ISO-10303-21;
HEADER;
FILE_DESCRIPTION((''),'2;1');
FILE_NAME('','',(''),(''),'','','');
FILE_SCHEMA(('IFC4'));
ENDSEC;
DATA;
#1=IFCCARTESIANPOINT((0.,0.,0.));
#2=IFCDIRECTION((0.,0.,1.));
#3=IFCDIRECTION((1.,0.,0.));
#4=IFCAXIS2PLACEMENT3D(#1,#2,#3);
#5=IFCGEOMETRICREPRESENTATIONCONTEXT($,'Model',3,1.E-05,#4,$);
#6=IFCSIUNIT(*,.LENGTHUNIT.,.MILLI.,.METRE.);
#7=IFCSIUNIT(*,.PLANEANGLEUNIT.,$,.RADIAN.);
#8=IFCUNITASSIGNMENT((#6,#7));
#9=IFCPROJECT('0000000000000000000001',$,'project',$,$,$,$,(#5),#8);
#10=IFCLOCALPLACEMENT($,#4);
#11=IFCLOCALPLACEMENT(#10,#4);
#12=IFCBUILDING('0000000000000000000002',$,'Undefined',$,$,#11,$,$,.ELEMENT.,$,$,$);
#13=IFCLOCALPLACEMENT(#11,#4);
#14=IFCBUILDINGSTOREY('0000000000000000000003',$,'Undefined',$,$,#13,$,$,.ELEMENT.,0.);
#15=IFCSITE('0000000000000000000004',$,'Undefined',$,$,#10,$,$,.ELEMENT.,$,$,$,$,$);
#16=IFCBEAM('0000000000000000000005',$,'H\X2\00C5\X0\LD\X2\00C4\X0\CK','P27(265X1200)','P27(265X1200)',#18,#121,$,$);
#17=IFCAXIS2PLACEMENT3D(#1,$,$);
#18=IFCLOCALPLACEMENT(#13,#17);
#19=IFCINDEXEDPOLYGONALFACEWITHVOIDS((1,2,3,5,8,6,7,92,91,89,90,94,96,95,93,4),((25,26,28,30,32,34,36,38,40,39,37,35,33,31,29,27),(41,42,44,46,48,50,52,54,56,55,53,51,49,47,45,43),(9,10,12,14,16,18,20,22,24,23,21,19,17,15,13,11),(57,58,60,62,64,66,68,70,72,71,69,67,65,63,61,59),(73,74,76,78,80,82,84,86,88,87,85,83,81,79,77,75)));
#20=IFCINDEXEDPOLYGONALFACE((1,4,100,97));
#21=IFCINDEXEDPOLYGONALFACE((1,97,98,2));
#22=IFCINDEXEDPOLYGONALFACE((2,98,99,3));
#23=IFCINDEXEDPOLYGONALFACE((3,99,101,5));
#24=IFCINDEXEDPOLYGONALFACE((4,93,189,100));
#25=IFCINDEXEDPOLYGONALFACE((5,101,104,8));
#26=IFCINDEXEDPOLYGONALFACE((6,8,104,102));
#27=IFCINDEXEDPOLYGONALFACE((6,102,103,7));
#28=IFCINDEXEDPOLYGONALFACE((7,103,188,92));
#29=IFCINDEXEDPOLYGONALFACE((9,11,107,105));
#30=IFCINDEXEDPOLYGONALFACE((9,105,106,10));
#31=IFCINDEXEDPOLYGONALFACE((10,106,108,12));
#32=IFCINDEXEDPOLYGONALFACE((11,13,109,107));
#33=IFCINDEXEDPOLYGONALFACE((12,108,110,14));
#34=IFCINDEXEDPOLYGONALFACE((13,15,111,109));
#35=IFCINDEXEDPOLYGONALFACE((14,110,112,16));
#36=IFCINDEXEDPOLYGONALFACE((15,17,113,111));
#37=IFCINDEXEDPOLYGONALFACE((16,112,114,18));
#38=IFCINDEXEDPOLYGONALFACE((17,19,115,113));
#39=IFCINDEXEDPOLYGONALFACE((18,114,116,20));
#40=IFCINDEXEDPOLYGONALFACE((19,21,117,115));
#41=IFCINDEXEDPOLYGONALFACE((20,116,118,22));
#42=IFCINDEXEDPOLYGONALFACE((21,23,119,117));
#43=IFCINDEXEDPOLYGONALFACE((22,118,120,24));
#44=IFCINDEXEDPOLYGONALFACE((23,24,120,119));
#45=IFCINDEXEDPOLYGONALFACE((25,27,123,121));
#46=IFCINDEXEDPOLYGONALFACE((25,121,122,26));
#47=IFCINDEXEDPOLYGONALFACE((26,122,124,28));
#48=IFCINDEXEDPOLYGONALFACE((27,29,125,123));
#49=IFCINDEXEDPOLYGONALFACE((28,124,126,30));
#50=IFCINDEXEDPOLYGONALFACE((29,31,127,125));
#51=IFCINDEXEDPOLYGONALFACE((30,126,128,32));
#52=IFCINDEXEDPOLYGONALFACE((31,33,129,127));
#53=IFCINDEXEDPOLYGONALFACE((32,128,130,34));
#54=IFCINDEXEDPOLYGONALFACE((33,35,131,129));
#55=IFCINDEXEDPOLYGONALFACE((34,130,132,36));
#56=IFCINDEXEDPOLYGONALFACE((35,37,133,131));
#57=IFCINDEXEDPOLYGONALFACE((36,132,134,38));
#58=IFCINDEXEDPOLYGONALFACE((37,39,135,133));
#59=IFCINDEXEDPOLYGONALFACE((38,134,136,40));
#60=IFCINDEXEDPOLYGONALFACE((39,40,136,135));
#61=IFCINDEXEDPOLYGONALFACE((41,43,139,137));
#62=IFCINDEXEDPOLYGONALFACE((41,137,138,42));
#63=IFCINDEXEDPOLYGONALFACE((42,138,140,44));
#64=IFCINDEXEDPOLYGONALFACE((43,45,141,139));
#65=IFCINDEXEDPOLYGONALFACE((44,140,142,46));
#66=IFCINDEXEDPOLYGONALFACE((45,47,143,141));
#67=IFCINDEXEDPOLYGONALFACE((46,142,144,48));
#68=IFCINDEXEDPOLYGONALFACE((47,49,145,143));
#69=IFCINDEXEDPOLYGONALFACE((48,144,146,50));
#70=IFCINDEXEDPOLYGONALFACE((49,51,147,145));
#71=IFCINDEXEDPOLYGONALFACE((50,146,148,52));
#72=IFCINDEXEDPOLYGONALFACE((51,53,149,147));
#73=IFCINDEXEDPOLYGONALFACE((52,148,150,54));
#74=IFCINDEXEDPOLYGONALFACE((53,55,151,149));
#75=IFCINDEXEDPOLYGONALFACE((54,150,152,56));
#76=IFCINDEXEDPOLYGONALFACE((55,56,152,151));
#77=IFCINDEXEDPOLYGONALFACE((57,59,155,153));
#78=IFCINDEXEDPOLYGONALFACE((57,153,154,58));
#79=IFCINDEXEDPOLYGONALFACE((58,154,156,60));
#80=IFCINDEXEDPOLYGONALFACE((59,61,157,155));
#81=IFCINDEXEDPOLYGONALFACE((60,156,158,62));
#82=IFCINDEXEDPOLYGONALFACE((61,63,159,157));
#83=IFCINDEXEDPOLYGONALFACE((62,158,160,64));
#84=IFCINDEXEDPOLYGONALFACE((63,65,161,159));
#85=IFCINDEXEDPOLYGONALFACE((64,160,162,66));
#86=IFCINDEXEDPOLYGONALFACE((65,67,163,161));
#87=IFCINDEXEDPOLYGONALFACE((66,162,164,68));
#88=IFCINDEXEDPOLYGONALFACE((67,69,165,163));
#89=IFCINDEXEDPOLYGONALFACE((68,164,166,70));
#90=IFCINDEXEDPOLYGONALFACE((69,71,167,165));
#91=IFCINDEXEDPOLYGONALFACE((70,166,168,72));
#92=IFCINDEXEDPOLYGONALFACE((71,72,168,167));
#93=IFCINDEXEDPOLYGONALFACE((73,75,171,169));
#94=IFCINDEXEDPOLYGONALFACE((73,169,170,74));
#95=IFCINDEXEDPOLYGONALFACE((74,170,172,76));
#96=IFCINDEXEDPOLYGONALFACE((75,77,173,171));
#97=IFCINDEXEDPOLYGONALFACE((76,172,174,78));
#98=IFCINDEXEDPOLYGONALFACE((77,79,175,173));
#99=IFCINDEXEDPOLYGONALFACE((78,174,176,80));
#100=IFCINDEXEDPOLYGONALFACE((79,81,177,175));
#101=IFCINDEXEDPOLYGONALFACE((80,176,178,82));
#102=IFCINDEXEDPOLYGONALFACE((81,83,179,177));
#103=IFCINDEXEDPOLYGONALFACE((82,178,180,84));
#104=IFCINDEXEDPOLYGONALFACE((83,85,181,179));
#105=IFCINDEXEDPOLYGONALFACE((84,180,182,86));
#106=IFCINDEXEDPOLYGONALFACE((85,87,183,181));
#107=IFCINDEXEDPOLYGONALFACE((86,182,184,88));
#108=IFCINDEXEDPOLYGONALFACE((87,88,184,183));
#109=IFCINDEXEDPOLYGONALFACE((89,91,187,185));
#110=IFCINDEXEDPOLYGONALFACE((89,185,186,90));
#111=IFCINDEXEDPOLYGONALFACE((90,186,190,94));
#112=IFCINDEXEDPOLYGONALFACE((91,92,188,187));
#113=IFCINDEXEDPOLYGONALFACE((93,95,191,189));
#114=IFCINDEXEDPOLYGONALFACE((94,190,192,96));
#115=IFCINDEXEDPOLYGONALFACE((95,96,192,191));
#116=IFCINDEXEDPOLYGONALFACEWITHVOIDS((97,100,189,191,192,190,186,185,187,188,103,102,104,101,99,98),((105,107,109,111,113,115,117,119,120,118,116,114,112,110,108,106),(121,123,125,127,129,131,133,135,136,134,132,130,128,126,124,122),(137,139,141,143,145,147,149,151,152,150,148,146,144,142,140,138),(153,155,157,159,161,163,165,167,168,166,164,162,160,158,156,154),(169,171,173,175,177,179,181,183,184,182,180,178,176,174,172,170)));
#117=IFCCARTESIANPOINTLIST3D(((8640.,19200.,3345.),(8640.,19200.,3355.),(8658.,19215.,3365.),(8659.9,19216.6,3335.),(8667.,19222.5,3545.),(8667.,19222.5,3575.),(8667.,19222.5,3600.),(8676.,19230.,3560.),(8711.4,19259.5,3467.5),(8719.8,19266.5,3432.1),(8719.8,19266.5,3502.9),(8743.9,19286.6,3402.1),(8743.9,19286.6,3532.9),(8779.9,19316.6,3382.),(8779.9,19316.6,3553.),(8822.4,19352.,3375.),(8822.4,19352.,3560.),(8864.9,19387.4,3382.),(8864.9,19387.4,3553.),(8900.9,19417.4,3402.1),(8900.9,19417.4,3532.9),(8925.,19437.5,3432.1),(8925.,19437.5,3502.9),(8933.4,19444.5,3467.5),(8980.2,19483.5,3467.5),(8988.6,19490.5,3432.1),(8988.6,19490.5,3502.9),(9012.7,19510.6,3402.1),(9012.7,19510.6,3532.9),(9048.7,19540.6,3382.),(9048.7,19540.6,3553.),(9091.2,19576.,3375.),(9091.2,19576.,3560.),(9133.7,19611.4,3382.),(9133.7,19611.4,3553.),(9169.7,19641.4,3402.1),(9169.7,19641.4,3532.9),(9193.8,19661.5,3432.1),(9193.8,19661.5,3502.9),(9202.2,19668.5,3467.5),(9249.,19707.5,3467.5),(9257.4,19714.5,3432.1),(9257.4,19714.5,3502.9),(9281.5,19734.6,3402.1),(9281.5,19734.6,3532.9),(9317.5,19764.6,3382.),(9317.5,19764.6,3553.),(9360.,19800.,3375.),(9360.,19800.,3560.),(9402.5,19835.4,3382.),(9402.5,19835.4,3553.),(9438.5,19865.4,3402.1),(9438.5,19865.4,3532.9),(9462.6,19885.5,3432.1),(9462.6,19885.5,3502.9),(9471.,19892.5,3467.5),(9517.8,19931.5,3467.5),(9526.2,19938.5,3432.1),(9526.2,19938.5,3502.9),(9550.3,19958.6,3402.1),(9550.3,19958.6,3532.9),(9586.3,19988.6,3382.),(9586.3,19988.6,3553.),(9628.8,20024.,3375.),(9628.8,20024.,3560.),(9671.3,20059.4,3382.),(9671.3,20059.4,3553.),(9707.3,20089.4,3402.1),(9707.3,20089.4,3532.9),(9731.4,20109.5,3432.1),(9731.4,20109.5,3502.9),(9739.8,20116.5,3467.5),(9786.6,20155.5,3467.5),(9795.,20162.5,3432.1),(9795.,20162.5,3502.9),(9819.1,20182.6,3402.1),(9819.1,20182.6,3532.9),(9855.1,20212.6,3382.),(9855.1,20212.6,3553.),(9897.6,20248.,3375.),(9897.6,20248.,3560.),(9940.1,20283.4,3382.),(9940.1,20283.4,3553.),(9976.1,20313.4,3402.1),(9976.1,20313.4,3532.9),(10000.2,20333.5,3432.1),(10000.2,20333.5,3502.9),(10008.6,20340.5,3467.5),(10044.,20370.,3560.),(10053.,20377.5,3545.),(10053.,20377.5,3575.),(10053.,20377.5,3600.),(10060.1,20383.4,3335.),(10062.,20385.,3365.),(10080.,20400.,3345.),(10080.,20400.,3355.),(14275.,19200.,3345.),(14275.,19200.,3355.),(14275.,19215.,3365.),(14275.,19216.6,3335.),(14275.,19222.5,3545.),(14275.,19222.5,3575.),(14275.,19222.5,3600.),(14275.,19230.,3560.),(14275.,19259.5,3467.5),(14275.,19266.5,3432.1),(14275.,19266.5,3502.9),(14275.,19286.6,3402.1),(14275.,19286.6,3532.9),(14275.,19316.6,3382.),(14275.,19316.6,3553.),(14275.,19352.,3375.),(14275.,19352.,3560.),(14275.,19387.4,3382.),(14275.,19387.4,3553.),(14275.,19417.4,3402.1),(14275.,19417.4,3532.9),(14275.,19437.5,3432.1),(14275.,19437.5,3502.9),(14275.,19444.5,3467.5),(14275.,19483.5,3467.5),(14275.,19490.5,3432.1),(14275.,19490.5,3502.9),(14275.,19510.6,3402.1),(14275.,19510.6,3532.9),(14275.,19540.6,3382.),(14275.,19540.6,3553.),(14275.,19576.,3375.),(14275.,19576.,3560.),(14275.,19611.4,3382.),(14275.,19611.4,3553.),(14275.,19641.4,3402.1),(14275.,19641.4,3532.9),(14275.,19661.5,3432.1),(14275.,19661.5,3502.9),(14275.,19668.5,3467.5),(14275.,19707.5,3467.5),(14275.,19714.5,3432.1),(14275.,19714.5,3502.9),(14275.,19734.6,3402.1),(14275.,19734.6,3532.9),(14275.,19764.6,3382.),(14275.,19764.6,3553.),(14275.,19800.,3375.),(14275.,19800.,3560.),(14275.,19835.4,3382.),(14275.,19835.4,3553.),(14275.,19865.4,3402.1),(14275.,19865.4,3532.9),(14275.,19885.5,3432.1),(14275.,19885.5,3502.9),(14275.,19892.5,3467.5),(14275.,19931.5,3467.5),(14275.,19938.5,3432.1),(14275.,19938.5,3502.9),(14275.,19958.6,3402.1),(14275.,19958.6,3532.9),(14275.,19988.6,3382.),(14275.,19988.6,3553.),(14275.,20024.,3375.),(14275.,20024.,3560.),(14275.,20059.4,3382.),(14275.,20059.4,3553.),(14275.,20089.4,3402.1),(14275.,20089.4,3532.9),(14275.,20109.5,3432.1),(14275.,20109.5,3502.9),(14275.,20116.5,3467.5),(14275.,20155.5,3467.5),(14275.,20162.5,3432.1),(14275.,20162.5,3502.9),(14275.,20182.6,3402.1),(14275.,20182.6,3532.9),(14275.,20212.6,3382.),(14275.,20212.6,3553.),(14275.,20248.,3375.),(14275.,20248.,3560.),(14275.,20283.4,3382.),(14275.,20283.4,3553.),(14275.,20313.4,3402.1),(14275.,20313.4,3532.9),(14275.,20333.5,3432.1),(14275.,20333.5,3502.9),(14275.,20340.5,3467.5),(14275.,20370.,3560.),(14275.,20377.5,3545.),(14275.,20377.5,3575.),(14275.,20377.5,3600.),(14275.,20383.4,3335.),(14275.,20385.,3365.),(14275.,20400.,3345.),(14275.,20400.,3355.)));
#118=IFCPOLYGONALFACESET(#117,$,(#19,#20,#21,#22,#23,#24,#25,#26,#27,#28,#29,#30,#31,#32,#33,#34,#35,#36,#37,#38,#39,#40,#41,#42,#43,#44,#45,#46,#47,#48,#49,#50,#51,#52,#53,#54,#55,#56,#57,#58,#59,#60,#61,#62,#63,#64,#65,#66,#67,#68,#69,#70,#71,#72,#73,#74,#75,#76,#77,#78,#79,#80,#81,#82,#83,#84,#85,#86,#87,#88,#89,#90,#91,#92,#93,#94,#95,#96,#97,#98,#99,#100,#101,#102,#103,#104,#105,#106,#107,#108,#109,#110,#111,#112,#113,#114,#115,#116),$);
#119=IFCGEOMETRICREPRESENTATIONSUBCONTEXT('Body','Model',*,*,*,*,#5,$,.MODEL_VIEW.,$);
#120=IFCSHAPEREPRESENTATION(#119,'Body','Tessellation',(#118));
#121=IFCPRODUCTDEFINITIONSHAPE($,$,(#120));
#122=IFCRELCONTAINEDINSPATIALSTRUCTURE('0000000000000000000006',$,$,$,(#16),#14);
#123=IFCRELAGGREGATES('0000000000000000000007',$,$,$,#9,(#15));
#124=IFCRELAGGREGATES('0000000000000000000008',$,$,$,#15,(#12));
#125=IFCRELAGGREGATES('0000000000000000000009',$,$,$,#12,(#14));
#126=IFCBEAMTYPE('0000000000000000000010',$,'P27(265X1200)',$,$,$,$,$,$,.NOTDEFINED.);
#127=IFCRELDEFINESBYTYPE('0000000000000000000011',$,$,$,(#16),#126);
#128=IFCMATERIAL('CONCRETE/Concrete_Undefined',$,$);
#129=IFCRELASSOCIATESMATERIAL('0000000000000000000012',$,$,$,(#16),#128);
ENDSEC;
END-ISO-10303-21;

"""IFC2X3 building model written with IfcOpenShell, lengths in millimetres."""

from ifc_helpers import new_model, si_unit, frame, origin_with_axes, place, context, subcontext, project, spatial, polyline, outline, extrude, clip, halfspace, material, type_object, element, save


model = new_model("IFC2X3")

# Units and contexts
model_context = context("Model", 3, precision=1e-05, world=origin_with_axes())
body_context = subcontext(model_context, "Body", "Model", "MODEL_VIEW")
ifc_project = project(units=[si_unit("LENGTHUNIT", "METRE", prefix="MILLI"), si_unit("PLANEANGLEUNIT", "RADIAN")], contexts=[model_context])

# Site, building, storey
site_placement = place(None, origin_with_axes())
site = spatial("IfcSite", under=ifc_project, at=site_placement, Name="Undefined", CompositionType="ELEMENT")
building_placement = place(site_placement, origin_with_axes())
building = spatial("IfcBuilding", under=site, at=building_placement, Name="Undefined", CompositionType="ELEMENT")
storey_placement = place(building_placement, origin_with_axes())
storey = spatial("IfcBuildingStorey", under=building, at=storey_placement, Name="Undefined", CompositionType="ELEMENT", Elevation=0.0)

# Beam
ifc_material_1 = material(Name="CONCRETE/Concrete_Undefined")
beam_type_1 = type_object("IfcBeamType", Name="P27(265X1200)", PredefinedType="NOTDEFINED")
beam_1_placement = place(storey_placement, frame((8640.0, 19800.0, 3467.5), z_axis=(0.0, 0.0, 1.0), x_axis=(1.0, 0.0, 0.0)))
element("IfcBeam", 1, at=beam_1_placement, inside=storey, type_object=beam_type_1, material=ifc_material_1, Name="HÅLDÄCK", Description="P27(265X1200)", ObjectType="P27(265X1200)", context=body_context, shape_type="Clipping", body=[
    clip(extrude(outline(polyline([(-583.4, -132.5), (-600.0, -122.5), (-600.0, -112.5), (-585.0, -102.5), (-577.5, 77.5), (-570.0, 92.5), (-577.5, 107.5), (-577.5, 132.5), (577.5, 132.5), (577.5, 107.5), (570.0, 92.5), (577.5, 77.5), (585.0, -102.5), (600.0, -112.5), (600.0, -122.5), (583.4, -132.5), (-583.4, -132.5)]), holes=[polyline([(-513.4, 65.4), (-533.5, 35.4), (-540.5, 0.0), (-533.5, -35.4), (-513.4, -65.4), (-483.4, -85.5), (-448.0, -92.5), (-412.6, -85.5), (-382.6, -65.4), (-362.5, -35.4), (-355.5, 0.0), (-362.5, 35.4), (-382.6, 65.4), (-412.6, 85.5), (-448.0, 92.5), (-483.4, 85.5), (-513.4, 65.4)]), polyline([(-289.4, 65.4), (-309.5, 35.4), (-316.5, 0.0), (-309.5, -35.4), (-289.4, -65.4), (-259.4, -85.5), (-224.0, -92.5), (-188.6, -85.5), (-158.6, -65.4), (-138.5, -35.4), (-131.5, 0.0), (-138.5, 35.4), (-158.6, 65.4), (-188.6, 85.5), (-224.0, 92.5), (-259.4, 85.5), (-289.4, 65.4)]), polyline([(-65.4, 65.4), (-85.5, 35.4), (-92.5, 0.0), (-85.5, -35.4), (-65.4, -65.4), (-35.4, -85.5), (0.0, -92.5), (35.4, -85.5), (65.4, -65.4), (85.5, -35.4), (92.5, 0.0), (85.5, 35.4), (65.4, 65.4), (35.4, 85.5), (0.0, 92.5), (-35.4, 85.5), (-65.4, 65.4)]), polyline([(158.6, 65.4), (138.5, 35.4), (131.5, 0.0), (138.5, -35.4), (158.6, -65.4), (188.6, -85.5), (224.0, -92.5), (259.4, -85.5), (289.4, -65.4), (309.5, -35.4), (316.5, 0.0), (309.5, 35.4), (289.4, 65.4), (259.4, 85.5), (224.0, 92.5), (188.6, 85.5), (158.6, 65.4)]), polyline([(382.6, 65.4), (362.5, 35.4), (355.5, 0.0), (362.5, -35.4), (382.6, -65.4), (412.6, -85.5), (448.0, -92.5), (483.4, -85.5), (513.4, -65.4), (533.5, -35.4), (540.5, 0.0), (533.5, 35.4), (513.4, 65.4), (483.4, 85.5), (448.0, 92.5), (412.6, 85.5), (382.6, 65.4)])]), frame((5635.0, 0.0, 0.0), z_axis=(-1.0, 0.0, 0.0), x_axis=(0.0, -1.0, 0.0)), (0.0, 0.0, 1.0), 5642.2), halfspace(frame((0.0, -600.0, 132.5), z_axis=(-0.640184, 0.768221, 0.0), x_axis=(0.0, 0.0, 1.0)), False)),
])

save(model, "model.ifc")
